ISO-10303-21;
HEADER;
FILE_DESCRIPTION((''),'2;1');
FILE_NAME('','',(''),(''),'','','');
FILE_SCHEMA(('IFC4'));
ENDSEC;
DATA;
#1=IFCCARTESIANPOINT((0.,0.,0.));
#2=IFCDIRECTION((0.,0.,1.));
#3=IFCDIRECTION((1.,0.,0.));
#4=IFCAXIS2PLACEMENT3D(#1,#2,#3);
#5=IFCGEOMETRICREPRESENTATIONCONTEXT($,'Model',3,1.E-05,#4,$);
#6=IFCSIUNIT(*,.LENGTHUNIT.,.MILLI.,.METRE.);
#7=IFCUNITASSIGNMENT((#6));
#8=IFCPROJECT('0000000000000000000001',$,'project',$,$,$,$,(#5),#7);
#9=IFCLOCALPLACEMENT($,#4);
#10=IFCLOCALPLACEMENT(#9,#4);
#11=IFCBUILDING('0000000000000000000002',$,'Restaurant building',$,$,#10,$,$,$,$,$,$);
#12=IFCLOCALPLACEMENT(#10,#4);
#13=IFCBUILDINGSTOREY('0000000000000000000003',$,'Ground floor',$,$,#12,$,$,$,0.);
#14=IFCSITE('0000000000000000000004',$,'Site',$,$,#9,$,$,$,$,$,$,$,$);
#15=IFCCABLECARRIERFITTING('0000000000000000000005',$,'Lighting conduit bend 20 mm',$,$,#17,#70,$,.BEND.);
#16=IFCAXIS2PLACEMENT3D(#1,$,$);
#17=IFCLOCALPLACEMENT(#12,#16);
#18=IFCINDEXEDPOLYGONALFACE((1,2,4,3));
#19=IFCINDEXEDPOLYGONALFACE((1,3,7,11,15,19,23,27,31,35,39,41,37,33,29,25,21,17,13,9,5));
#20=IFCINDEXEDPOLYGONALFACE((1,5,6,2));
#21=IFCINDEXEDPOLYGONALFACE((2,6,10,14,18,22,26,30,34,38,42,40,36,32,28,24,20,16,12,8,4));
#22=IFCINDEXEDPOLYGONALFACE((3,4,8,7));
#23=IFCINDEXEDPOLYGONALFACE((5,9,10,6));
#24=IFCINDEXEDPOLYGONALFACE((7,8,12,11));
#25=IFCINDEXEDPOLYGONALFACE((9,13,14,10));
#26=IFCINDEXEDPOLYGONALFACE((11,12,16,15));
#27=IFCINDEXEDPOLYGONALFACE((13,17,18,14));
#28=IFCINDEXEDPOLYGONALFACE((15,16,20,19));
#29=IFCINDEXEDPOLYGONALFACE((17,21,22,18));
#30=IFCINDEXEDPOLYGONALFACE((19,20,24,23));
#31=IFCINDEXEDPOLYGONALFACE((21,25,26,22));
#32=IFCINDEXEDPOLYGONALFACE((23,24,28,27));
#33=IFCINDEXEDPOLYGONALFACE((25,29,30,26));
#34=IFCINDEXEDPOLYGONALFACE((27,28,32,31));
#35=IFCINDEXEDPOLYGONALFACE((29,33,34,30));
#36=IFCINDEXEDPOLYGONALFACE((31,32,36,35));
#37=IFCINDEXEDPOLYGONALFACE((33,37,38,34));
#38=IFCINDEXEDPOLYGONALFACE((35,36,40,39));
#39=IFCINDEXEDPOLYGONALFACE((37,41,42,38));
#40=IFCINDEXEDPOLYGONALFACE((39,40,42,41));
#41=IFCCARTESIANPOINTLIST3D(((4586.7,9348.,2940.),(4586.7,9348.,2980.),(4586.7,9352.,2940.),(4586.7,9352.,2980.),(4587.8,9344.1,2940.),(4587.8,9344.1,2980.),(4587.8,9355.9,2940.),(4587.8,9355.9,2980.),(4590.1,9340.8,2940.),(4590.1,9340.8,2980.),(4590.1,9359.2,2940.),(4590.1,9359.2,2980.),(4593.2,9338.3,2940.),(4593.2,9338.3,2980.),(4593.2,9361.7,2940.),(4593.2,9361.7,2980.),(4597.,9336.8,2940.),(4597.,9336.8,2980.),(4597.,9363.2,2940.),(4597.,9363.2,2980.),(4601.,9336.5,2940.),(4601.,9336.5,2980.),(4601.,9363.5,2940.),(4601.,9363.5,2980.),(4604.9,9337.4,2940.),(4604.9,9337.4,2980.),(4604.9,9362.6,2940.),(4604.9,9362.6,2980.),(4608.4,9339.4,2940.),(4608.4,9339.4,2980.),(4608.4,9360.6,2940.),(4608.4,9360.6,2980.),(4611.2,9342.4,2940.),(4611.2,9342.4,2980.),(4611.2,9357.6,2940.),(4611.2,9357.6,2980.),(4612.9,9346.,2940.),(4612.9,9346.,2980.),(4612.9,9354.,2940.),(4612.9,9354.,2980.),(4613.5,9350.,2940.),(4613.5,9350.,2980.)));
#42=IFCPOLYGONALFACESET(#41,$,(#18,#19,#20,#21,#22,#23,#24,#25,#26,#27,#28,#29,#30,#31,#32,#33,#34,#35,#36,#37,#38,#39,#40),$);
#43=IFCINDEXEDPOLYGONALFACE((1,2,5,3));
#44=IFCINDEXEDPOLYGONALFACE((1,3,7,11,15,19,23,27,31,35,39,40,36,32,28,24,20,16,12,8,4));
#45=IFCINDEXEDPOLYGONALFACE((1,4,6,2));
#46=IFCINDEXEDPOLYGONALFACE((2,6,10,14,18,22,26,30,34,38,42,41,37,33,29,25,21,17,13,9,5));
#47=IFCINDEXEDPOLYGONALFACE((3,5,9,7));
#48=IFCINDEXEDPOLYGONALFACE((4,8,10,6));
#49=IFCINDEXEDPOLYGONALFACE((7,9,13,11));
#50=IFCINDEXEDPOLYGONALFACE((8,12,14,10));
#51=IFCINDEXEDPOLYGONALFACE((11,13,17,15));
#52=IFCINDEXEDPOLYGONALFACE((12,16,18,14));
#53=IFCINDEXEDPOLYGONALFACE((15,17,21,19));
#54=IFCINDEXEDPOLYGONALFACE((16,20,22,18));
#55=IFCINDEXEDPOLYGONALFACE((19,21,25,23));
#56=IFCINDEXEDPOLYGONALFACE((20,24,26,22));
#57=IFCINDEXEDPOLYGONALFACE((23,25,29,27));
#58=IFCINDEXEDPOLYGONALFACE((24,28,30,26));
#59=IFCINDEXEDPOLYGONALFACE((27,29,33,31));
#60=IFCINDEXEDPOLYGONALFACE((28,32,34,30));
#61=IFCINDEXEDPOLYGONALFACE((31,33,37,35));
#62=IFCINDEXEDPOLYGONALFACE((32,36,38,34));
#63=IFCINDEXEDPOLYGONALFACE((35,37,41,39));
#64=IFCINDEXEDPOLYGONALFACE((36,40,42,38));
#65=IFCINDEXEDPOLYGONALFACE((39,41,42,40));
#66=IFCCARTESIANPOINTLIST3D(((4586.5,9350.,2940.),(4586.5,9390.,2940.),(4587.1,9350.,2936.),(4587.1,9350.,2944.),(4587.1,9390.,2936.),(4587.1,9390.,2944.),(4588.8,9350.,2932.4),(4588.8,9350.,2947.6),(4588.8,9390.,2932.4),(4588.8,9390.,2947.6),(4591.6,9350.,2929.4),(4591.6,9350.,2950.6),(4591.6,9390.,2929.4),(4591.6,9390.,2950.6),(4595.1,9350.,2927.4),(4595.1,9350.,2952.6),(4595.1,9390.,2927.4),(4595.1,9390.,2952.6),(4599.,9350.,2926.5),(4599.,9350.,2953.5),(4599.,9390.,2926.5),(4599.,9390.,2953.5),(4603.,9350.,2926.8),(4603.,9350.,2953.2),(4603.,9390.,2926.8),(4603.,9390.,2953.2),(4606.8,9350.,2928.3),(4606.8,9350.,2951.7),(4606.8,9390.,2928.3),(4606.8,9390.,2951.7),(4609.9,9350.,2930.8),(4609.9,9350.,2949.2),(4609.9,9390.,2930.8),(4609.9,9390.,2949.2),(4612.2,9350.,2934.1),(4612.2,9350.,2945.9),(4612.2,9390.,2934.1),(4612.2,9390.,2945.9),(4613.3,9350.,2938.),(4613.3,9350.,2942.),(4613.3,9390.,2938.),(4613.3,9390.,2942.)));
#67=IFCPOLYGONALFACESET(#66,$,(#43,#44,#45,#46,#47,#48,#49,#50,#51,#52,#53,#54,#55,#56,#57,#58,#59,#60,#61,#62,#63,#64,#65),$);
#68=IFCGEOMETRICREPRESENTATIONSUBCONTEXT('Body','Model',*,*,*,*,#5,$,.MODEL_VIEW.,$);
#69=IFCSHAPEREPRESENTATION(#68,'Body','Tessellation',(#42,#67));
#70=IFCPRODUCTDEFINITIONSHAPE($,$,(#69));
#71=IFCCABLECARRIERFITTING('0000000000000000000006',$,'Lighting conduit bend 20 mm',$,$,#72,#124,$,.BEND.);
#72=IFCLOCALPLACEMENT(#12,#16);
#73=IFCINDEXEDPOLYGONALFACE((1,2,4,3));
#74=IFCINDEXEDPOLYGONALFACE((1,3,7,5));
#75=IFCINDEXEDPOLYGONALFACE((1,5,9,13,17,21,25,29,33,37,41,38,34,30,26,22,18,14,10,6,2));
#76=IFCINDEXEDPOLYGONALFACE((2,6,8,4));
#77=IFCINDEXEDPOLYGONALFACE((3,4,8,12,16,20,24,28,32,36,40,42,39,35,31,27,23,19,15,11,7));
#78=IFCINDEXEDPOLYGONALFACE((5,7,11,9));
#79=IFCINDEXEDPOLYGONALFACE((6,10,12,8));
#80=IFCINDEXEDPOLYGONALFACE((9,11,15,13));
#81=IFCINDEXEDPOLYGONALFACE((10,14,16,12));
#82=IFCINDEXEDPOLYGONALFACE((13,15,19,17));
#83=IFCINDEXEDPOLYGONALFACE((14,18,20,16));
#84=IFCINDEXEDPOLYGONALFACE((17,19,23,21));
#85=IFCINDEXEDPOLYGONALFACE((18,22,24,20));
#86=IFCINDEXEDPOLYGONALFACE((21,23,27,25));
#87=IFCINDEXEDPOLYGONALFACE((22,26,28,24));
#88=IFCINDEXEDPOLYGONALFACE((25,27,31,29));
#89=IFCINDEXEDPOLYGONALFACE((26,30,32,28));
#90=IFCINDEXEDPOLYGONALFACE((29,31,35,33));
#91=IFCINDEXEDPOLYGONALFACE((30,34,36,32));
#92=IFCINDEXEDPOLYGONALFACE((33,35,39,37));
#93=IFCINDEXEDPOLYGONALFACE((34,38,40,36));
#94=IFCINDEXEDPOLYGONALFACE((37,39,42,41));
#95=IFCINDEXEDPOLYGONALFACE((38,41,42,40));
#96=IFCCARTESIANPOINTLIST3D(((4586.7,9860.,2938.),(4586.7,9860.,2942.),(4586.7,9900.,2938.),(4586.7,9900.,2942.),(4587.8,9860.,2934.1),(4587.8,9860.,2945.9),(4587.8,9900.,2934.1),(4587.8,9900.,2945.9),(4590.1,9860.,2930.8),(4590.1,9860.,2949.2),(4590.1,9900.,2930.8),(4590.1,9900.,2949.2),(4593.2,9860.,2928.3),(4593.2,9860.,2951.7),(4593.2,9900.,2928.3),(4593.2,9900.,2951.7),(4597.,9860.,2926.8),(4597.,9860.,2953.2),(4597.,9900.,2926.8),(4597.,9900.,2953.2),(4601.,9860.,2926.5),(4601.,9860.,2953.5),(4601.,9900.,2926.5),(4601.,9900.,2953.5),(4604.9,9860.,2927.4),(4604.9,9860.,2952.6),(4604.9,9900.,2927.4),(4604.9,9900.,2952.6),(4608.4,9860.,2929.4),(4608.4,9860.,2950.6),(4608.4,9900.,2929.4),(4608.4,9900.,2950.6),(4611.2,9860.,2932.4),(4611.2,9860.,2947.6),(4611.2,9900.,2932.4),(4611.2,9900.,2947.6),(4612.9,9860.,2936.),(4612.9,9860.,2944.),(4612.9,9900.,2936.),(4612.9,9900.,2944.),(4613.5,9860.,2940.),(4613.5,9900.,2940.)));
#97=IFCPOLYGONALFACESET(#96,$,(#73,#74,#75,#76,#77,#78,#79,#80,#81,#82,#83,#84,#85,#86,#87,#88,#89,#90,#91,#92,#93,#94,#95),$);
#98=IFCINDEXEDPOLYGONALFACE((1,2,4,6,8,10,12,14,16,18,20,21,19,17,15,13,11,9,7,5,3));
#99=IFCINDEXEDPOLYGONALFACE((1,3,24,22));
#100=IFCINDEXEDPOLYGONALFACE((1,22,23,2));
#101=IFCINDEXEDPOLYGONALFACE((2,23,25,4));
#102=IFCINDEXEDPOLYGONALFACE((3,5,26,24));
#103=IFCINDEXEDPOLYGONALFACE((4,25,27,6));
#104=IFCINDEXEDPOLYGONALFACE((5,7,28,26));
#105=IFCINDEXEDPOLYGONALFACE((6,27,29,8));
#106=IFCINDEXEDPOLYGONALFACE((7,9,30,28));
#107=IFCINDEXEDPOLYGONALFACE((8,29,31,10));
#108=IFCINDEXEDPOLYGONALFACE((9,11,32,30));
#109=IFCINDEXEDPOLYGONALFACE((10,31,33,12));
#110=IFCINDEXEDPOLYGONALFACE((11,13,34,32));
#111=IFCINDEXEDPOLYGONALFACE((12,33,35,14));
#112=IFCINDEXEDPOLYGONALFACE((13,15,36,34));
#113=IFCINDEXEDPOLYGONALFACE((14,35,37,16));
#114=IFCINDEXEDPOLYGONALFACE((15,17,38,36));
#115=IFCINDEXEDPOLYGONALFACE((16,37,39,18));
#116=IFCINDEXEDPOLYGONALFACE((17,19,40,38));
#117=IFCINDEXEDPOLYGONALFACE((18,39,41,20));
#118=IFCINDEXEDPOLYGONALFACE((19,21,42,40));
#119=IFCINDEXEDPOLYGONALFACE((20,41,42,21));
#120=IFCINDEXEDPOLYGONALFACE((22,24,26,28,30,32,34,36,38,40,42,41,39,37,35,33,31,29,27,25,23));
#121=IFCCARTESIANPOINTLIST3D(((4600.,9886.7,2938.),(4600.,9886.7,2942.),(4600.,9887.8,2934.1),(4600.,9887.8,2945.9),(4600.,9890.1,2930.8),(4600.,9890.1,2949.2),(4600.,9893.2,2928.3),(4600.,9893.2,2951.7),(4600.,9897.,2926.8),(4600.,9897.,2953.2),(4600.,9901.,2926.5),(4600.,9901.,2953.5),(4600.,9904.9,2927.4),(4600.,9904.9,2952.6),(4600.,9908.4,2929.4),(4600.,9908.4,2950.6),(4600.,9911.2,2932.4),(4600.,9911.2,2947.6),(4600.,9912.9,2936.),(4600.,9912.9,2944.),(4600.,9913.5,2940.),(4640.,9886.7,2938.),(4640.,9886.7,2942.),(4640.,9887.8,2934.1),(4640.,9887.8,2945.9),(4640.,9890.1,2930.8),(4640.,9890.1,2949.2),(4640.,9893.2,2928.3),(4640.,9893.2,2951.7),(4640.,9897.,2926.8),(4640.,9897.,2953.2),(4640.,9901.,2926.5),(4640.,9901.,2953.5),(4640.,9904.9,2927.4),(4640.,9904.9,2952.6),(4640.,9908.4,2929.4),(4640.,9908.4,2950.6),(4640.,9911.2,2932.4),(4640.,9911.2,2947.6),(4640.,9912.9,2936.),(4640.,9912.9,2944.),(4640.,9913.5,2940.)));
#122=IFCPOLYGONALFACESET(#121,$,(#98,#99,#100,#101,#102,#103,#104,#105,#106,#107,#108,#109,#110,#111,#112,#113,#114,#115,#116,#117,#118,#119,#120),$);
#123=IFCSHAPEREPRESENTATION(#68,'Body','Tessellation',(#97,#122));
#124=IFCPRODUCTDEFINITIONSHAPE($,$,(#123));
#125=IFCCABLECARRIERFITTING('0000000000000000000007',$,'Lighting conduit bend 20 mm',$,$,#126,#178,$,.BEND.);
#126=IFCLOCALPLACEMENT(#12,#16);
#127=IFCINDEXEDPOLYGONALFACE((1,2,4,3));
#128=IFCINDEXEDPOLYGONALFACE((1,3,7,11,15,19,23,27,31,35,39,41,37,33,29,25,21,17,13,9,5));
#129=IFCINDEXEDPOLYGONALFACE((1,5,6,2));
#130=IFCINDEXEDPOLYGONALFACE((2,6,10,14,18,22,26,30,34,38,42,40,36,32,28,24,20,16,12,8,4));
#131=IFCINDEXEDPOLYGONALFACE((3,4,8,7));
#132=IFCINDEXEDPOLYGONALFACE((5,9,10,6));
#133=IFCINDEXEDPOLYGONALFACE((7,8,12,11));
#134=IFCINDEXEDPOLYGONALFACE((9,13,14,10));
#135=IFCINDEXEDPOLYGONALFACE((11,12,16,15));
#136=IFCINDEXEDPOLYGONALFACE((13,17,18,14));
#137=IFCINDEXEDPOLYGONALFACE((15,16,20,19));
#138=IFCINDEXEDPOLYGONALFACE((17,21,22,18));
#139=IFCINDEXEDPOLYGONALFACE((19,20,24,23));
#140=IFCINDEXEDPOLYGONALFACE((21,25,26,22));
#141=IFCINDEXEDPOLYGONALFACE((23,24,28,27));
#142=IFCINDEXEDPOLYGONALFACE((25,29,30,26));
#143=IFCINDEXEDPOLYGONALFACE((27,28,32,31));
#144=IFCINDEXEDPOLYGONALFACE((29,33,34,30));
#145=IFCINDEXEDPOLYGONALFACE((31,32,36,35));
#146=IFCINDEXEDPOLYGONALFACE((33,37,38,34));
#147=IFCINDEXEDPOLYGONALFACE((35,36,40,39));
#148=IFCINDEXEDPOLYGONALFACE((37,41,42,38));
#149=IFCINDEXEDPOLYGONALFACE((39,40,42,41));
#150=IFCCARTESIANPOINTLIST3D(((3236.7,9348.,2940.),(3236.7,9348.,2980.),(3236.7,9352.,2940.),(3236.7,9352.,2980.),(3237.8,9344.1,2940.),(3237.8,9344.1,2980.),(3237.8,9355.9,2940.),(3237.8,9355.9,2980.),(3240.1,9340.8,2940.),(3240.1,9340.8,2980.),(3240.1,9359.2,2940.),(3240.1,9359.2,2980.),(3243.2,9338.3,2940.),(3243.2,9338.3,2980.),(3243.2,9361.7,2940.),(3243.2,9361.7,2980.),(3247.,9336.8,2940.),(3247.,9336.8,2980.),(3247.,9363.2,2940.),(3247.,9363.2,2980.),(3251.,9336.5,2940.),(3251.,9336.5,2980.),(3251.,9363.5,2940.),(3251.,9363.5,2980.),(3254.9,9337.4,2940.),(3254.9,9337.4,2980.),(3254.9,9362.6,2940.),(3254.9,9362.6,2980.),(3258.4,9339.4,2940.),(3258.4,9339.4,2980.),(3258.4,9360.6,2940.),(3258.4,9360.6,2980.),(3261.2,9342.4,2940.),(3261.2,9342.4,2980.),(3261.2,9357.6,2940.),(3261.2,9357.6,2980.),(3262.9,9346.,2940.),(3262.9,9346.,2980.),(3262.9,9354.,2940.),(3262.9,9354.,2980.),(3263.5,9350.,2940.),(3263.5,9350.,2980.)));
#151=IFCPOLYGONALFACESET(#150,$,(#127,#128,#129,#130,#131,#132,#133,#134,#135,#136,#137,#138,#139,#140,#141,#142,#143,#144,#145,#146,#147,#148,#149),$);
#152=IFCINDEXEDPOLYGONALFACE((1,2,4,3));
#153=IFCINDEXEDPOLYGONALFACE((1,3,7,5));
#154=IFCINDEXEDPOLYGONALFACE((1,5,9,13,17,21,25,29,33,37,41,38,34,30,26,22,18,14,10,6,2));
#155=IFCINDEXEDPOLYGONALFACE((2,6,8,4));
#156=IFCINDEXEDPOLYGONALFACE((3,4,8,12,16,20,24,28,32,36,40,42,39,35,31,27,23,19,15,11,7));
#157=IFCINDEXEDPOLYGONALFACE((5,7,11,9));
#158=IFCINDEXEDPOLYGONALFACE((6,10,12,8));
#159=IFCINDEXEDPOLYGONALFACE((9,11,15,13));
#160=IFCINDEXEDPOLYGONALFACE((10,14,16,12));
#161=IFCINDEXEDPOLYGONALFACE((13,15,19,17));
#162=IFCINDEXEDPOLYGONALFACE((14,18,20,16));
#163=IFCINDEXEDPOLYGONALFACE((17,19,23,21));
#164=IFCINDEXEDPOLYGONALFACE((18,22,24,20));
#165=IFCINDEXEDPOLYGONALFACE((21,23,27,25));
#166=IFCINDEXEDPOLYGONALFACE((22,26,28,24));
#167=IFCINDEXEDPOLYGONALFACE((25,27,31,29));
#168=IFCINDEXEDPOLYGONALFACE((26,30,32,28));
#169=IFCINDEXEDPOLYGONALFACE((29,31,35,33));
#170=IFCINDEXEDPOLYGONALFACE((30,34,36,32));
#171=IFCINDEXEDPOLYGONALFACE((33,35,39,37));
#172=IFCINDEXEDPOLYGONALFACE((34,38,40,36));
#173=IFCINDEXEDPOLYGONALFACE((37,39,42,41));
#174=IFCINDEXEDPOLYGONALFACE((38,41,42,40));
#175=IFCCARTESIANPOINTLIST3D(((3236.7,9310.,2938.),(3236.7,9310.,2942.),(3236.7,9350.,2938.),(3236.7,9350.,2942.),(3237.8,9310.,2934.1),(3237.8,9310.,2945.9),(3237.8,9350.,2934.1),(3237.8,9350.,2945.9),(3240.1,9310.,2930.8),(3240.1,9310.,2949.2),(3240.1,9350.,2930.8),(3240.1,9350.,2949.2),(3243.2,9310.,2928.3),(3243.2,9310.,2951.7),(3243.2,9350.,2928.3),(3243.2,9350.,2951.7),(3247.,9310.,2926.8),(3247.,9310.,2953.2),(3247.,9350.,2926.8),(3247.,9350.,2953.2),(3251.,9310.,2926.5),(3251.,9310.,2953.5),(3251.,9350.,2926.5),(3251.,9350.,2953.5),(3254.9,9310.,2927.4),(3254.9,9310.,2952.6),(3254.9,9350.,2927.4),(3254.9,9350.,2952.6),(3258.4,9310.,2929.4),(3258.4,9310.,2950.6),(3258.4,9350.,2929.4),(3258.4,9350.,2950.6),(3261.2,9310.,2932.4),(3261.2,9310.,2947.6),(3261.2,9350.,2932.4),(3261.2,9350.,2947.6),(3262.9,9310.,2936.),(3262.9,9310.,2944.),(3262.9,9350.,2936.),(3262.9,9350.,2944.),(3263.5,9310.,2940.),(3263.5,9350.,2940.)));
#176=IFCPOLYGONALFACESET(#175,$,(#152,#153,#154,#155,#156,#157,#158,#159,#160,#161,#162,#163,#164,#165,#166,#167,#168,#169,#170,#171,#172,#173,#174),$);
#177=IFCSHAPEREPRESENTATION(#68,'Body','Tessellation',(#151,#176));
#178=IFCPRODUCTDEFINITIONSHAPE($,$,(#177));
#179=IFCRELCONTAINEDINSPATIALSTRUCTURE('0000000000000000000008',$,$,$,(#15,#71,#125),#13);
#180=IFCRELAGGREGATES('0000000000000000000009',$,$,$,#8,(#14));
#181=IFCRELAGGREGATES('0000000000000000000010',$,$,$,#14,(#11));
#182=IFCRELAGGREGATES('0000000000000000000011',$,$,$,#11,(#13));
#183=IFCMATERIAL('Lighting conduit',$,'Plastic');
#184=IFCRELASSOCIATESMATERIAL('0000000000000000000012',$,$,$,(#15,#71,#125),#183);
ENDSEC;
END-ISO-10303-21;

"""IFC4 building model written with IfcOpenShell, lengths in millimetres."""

from ifc_helpers import new_model, si_unit, frame, origin, origin_with_axes, origin_2d, place, context, subcontext, project, spatial, circle, extrude, material, element, save


model = new_model("IFC4")

# Units and contexts
model_context = context("Model", 3, precision=1e-05, world=origin_with_axes())
body_context = subcontext(model_context, "Body", "Model", "MODEL_VIEW")
ifc_project = project(units=[si_unit("LENGTHUNIT", "METRE", prefix="MILLI")], contexts=[model_context])

# Site, building, storey
site_placement = place(None, origin_with_axes())
site = spatial("IfcSite", under=ifc_project, at=site_placement, Name="Site")
building_placement = place(site_placement, origin_with_axes())
building = spatial("IfcBuilding", under=site, at=building_placement, Name="Restaurant building")
storey_placement = place(building_placement, origin_with_axes())
storey = spatial("IfcBuildingStorey", under=building, at=storey_placement, Name="Ground floor", Elevation=0.0)

# Shared definitions
ifc_material_1 = material(Name="Lighting conduit", Category="Plastic")

# Cable carrier fittings
cable_carrier_fitting_1_placement = place(storey_placement, frame((4600.0, 9350.0, 2940.0)))
element("IfcCableCarrierFitting", 1, at=cable_carrier_fitting_1_placement, inside=storey, material=ifc_material_1, Name="Lighting conduit bend 20 mm", PredefinedType="BEND", context=body_context, shape_type="SweptSolid", body=[
    extrude(circle(Radius=13.5, at=origin_2d()), origin(), (0.0, 0.0, 1.0), 40.0),
    extrude(circle(Radius=13.5, at=origin_2d()), frame((0.0, 0.0, 0.0), z_axis=(0.0, 1.0, 0.0), x_axis=(-1.0, 0.0, 0.0)), (0.0, 0.0, 1.0), 40.0),
])
cable_carrier_fitting_2_placement = place(storey_placement, frame((4600.0, 9900.0, 2940.0)))
element("IfcCableCarrierFitting", 2, at=cable_carrier_fitting_2_placement, inside=storey, material=ifc_material_1, Name="Lighting conduit bend 20 mm", PredefinedType="BEND", context=body_context, shape_type="SweptSolid", body=[
    extrude(circle(Radius=13.5, at=origin_2d()), frame((0.0, 0.0, 0.0), z_axis=(0.0, -1.0, 0.0), x_axis=(1.0, 0.0, 0.0)), (0.0, 0.0, 1.0), 40.0),
    extrude(circle(Radius=13.5, at=origin_2d()), frame((0.0, 0.0, 0.0), z_axis=(1.0, 0.0, 0.0), x_axis=(0.0, 1.0, 0.0)), (0.0, 0.0, 1.0), 40.0),
])
cable_carrier_fitting_3_placement = place(storey_placement, frame((3250.0, 9350.0, 2940.0)))
element("IfcCableCarrierFitting", 3, at=cable_carrier_fitting_3_placement, inside=storey, material=ifc_material_1, Name="Lighting conduit bend 20 mm", PredefinedType="BEND", context=body_context, shape_type="SweptSolid", body=[
    extrude(circle(Radius=13.5, at=origin_2d()), origin(), (0.0, 0.0, 1.0), 40.0),
    extrude(circle(Radius=13.5, at=origin_2d()), frame((0.0, 0.0, 0.0), z_axis=(0.0, -1.0, 0.0), x_axis=(1.0, 0.0, 0.0)), (0.0, 0.0, 1.0), 40.0),
])

save(model, "model.ifc")
